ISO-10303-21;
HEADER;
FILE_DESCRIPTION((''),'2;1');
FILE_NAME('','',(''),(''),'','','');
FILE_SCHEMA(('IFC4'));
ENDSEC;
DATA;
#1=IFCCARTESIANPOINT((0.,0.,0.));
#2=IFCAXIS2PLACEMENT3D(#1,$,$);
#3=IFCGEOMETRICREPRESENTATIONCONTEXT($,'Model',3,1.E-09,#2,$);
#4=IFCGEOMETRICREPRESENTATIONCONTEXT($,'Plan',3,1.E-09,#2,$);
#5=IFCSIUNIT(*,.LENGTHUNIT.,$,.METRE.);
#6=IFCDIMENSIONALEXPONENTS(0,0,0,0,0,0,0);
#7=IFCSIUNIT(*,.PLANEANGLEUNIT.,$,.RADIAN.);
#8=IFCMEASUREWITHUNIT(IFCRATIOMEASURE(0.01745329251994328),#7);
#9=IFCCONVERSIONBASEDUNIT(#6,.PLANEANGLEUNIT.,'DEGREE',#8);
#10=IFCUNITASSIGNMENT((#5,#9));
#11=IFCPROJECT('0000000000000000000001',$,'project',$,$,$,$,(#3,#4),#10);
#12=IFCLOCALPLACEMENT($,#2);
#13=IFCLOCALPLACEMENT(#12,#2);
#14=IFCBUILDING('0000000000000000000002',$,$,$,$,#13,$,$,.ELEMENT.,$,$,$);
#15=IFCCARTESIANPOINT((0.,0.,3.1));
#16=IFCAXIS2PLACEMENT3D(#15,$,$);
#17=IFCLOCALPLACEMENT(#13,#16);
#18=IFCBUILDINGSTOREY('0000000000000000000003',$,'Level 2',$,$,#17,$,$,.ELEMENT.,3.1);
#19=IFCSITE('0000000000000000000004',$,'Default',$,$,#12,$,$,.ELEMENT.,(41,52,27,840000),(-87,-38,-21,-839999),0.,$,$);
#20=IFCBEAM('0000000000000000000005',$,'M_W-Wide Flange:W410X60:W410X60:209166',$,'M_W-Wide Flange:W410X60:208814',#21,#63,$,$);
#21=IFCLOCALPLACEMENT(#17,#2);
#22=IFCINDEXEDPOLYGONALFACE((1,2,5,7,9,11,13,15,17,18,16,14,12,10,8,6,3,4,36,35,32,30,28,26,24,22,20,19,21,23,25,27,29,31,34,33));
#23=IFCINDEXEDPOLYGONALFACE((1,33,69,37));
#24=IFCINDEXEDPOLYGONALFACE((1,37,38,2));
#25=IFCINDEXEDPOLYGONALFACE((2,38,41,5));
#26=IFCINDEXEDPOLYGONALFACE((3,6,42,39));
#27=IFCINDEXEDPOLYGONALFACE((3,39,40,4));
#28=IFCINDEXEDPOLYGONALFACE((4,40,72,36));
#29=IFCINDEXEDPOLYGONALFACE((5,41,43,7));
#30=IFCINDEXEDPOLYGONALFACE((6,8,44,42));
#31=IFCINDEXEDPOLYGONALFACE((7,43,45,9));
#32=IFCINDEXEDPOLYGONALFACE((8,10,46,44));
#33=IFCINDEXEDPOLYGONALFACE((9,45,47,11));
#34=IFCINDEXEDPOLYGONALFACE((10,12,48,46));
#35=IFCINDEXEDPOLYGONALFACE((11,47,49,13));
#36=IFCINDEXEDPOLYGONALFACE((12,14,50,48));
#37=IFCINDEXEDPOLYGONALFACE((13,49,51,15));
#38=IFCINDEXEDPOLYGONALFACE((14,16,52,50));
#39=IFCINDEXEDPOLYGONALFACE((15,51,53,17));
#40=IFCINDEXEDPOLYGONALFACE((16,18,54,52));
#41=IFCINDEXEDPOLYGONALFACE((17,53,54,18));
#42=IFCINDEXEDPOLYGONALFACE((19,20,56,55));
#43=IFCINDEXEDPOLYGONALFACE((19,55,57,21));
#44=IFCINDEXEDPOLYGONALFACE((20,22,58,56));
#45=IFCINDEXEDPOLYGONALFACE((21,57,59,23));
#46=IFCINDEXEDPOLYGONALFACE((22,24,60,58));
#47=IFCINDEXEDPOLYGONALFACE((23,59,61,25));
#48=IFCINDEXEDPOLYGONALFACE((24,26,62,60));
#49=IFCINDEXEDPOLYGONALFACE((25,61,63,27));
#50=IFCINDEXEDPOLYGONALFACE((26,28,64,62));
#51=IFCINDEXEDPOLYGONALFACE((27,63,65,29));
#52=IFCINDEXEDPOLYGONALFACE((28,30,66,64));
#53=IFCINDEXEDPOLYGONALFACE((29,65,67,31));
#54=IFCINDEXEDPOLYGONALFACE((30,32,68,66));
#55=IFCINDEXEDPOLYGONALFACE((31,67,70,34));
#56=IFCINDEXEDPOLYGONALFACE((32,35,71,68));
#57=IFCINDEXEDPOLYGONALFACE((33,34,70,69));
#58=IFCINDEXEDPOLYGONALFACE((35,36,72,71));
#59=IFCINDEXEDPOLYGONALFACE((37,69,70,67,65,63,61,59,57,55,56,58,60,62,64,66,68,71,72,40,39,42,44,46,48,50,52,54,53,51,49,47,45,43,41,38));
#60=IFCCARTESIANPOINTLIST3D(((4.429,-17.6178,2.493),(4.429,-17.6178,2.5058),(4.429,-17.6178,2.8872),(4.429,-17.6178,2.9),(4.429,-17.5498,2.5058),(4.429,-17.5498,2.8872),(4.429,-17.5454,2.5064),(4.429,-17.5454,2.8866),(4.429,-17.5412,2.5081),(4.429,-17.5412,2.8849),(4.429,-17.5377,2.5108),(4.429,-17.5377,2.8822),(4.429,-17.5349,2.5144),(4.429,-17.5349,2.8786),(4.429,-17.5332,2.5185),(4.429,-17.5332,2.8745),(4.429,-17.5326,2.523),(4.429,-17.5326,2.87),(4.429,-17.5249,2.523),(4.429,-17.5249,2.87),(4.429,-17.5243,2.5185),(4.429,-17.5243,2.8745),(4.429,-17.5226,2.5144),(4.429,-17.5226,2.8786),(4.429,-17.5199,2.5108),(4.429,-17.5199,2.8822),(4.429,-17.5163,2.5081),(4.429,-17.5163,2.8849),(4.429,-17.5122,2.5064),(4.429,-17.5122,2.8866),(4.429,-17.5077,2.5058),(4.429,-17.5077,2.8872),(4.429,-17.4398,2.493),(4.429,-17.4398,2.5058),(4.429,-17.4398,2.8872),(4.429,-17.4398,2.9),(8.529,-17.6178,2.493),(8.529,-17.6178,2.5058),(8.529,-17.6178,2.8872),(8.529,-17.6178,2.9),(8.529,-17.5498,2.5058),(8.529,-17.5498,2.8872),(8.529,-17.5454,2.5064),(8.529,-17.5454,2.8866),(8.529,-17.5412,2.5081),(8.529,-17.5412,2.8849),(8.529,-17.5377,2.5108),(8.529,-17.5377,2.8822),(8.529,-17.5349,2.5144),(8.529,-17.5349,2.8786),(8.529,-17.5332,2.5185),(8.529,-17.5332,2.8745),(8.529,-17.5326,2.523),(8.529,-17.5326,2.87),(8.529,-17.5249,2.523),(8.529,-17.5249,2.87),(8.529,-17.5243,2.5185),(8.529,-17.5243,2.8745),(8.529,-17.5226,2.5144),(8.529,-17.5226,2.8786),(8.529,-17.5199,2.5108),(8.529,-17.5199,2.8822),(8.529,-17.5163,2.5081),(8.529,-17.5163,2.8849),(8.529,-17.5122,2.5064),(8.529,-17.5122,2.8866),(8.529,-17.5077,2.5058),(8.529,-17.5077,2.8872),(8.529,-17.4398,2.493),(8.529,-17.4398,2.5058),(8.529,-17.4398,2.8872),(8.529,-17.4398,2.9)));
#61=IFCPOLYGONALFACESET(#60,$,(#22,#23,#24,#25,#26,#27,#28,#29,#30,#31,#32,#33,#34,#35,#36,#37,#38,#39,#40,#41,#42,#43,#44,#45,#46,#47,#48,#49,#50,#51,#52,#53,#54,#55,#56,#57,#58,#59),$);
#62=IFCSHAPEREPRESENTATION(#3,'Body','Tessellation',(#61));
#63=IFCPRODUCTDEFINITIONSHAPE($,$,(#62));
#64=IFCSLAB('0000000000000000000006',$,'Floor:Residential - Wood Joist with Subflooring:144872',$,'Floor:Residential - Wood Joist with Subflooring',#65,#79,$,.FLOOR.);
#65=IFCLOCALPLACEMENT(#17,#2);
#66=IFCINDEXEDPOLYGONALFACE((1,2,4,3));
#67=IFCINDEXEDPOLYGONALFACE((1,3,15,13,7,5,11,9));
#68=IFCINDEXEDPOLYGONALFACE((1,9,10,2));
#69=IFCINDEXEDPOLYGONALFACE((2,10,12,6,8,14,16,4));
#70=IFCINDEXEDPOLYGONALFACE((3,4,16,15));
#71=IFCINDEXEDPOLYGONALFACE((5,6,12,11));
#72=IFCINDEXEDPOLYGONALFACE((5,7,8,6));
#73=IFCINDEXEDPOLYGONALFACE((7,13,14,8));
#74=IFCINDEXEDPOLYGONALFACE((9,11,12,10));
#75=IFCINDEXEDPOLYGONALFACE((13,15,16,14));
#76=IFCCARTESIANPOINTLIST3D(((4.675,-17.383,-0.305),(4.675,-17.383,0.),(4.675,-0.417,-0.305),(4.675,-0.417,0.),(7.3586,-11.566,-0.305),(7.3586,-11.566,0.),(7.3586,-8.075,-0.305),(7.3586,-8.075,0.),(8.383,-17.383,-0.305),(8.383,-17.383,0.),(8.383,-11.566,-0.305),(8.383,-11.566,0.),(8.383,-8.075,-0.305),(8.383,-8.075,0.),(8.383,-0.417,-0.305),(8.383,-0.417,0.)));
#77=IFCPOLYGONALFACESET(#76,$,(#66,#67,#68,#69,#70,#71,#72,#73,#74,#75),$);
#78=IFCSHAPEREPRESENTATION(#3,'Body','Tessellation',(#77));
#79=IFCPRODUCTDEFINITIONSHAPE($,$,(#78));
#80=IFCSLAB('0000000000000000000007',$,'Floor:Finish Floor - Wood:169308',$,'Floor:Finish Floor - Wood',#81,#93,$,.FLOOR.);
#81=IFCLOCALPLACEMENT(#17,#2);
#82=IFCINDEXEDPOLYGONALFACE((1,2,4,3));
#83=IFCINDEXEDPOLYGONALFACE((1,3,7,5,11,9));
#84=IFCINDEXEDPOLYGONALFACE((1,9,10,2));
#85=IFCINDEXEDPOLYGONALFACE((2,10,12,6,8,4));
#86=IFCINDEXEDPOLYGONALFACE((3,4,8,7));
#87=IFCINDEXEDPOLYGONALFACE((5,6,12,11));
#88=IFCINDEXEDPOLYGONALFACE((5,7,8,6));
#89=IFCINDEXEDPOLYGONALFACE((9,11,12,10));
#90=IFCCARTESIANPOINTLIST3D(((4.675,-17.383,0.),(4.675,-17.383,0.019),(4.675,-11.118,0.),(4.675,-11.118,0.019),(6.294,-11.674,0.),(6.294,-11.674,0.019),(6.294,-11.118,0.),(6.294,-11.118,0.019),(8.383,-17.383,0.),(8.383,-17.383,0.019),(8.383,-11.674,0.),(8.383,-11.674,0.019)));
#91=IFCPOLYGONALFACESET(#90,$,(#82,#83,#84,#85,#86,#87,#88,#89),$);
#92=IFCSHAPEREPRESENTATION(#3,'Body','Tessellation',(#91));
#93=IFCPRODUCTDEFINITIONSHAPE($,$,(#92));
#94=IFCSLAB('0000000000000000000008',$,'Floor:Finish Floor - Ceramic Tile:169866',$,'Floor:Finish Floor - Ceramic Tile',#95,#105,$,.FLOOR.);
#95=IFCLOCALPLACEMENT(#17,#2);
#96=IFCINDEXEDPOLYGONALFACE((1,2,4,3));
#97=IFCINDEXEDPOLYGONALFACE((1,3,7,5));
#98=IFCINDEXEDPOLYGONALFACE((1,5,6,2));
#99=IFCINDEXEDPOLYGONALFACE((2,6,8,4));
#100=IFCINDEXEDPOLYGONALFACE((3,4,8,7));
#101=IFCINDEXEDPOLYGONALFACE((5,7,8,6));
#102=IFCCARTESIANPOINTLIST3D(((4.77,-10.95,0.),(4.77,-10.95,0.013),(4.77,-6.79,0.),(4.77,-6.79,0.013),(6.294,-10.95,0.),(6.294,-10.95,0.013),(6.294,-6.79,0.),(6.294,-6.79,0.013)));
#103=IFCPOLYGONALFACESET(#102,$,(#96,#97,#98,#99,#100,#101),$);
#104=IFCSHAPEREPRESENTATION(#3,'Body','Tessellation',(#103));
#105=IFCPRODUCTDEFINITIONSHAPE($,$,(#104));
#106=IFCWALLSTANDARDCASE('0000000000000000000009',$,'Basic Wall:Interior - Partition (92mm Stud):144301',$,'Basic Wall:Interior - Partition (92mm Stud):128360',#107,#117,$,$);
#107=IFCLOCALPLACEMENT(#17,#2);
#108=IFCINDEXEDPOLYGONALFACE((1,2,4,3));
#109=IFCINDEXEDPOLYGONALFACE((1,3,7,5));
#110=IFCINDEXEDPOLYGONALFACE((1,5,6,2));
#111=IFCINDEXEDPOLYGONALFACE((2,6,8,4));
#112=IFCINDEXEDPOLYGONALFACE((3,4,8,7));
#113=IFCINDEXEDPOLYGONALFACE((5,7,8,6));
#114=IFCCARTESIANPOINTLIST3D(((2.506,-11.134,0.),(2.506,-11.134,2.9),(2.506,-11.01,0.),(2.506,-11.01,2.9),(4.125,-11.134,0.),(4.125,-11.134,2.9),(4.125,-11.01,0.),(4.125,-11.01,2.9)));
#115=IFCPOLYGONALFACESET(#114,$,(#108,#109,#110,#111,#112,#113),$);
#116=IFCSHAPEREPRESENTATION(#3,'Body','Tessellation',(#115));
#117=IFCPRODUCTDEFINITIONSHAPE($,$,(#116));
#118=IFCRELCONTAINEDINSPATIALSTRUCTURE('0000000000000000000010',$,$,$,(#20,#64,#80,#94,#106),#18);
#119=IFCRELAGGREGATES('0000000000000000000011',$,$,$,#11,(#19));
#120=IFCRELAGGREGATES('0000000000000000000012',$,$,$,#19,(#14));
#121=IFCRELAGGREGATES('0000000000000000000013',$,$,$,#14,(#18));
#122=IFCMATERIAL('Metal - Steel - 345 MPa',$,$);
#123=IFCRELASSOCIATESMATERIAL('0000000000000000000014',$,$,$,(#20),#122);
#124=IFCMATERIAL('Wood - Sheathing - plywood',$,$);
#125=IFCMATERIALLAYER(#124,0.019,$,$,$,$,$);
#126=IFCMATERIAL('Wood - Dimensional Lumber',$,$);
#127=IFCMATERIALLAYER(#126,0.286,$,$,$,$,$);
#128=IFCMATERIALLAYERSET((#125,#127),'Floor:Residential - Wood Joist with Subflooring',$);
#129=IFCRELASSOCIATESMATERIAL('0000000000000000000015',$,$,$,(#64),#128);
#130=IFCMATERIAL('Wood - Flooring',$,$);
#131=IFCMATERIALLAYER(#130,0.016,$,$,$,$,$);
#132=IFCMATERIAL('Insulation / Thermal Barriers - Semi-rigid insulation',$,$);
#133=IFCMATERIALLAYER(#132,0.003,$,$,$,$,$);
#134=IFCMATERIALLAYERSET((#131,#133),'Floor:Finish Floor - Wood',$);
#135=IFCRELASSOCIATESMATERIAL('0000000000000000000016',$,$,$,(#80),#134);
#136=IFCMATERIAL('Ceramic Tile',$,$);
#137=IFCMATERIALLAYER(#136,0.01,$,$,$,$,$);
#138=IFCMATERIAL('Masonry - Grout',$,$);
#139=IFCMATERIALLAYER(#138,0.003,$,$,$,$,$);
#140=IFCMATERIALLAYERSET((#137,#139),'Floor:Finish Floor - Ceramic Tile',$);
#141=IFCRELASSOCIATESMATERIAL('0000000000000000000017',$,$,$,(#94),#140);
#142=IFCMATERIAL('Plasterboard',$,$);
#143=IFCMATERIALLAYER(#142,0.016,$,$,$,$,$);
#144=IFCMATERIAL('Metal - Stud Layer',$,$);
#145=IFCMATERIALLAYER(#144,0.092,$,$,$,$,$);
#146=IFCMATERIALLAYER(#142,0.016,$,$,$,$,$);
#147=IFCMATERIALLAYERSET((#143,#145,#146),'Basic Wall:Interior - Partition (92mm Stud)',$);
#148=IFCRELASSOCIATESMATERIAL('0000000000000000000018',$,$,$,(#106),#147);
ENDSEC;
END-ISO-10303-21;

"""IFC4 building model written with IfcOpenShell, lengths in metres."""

from ifc_helpers import new_model, entity, si_unit, converted_unit, frame, frame_2d, origin, place, context, project, spatial, polyline, circle_curve, parameter, trimmed, segment, composite_curve, rectangle, outline, extrude, material, layer, layer_set, layer_usage, element, save


model = new_model("IFC4")

# Units and contexts
model_context = context("Model", 3, precision=1e-09, world=origin())
plan_context = context("Plan", 3, precision=1e-09, world=origin())
ifc_project = project(units=[si_unit("LENGTHUNIT", "METRE"), converted_unit("PLANEANGLEUNIT", "DEGREE", entity("IfcRatioMeasure", 0.01745329251994328), si_unit("PLANEANGLEUNIT", "RADIAN"), dimensions=[0, 0, 0, 0, 0, 0, 0])], contexts=[model_context, plan_context])

# Site, building, storey
site_placement = place(None, origin())
site = spatial("IfcSite", under=ifc_project, at=site_placement, Name="Default", CompositionType="ELEMENT", RefLatitude=(41, 52, 27, 840000), RefLongitude=(-87, -38, -21, -839999), RefElevation=0.0)
building_placement = place(site_placement, origin())
building = spatial("IfcBuilding", under=site, at=building_placement, CompositionType="ELEMENT")
storey_placement = place(building_placement, frame((0.0, 0.0, 3.1)))
storey = spatial("IfcBuildingStorey", under=building, at=storey_placement, Name="Level 2", CompositionType="ELEMENT", Elevation=3.1)

# Beam
ifc_material_1 = material(Name="Metal - Steel - 345 MPa")
beam_placement = place(storey_placement, frame((4.429, -17.5288, 2.9), z_axis=(0.0, 0.0, 1.0), x_axis=(0.0, -1.0, 0.0)))
element("IfcBeam", 1, at=beam_placement, inside=storey, material=ifc_material_1, Name="M_W-Wide Flange:W410X60:W410X60:209166", ObjectType="M_W-Wide Flange:W410X60:208814", context=model_context, shape_type="SweptSolid", body=[
    extrude(outline(composite_curve([segment(polyline([(-0.089, -0.1907), (-0.089, -0.2035)]), True, "CONTINUOUS"), segment(polyline([(-0.089, -0.2035), (0.089, -0.2035)]), True, "CONTINUOUS"), segment(polyline([(0.089, -0.2035), (0.089, -0.1907)]), True, "CONTINUOUS"), segment(polyline([(0.089, -0.1907), (0.021, -0.1907)]), True, "CONTINUOUS"), segment(trimmed(circle_curve(frame_2d((0.021, -0.1735), x_axis=(0.0, -1.0)), 0.0172), [parameter(270.0)], [parameter(360.0)], True, "PARAMETER"), False, "CONTINUOUS"), segment(polyline([(0.0038, -0.1735), (0.0038, 0.1735)]), True, "CONTINUOUS"), segment(trimmed(circle_curve(frame_2d((0.021, 0.1735), x_axis=(-1.0, 0.0)), 0.0172), [parameter(270.0)], [parameter(360.0)], True, "PARAMETER"), False, "CONTINUOUS"), segment(polyline([(0.021, 0.1907), (0.089, 0.1907)]), True, "CONTINUOUS"), segment(polyline([(0.089, 0.1907), (0.089, 0.2035)]), True, "CONTINUOUS"), segment(polyline([(0.089, 0.2035), (-0.089, 0.2035)]), True, "CONTINUOUS"), segment(polyline([(-0.089, 0.2035), (-0.089, 0.1907)]), True, "CONTINUOUS"), segment(polyline([(-0.089, 0.1907), (-0.0211, 0.1907)]), True, "CONTINUOUS"), segment(trimmed(circle_curve(frame_2d((-0.0211, 0.1735), x_axis=(0.0, 1.0)), 0.0172), [parameter(270.0)], [parameter(0.0)], True, "PARAMETER"), False, "CONTINUOUS"), segment(polyline([(-0.0039, 0.1735), (-0.0039, -0.1735)]), True, "CONTINUOUS"), segment(trimmed(circle_curve(frame_2d((-0.0211, -0.1735), x_axis=(1.0, 0.0)), 0.0172), [parameter(270.0)], [parameter(0.0)], True, "PARAMETER"), False, "CONTINUOUS"), segment(polyline([(-0.0211, -0.1907), (-0.089, -0.1907)]), True, "CONTINUOUS")], self_intersect=False)), frame((0.0, 0.0, -0.2035), z_axis=(0.0, -1.0, 0.0), x_axis=(1.0, 0.0, 0.0)), (0.0, 0.0, -1.0), 4.1),
])

# Slabs
ifc_material_2 = material(Name="Wood - Sheathing - plywood")
ifc_layer_1 = layer(ifc_material_2, 0.019)
ifc_material_3 = material(Name="Wood - Dimensional Lumber")
ifc_layer_2 = layer(ifc_material_3, 0.286)
ifc_layer_set_1 = layer_set([ifc_layer_1, ifc_layer_2], Name="Floor:Residential - Wood Joist with Subflooring")
ifc_layer_usage_1 = layer_usage(ifc_layer_set_1, "AXIS3", "POSITIVE", 0.0)
slab_1_placement = place(storey_placement, frame((4.675, -17.383, -0.305)))
element("IfcSlab", 2, at=slab_1_placement, inside=storey, material=ifc_layer_usage_1, Name="Floor:Residential - Wood Joist with Subflooring:144872", ObjectType="Floor:Residential - Wood Joist with Subflooring", PredefinedType="FLOOR", context=model_context, shape_type="SweptSolid", body=[
    extrude(outline(polyline([(-1.854, 8.483), (-1.854, 0.825), (-0.8296, 0.825), (-0.8296, -2.666), (-1.854, -2.666), (-1.854, -8.483), (1.854, -8.483), (1.854, 8.483), (-1.854, 8.483)])), frame((1.854, 8.483, 0.305), z_axis=(0.0, 0.0, -1.0), x_axis=(-1.0, 0.0, 0.0)), (0.0, 0.0, 1.0), 0.305),
])
ifc_material_4 = material(Name="Wood - Flooring")
ifc_layer_3 = layer(ifc_material_4, 0.016)
ifc_material_5 = material(Name="Insulation / Thermal Barriers - Semi-rigid insulation")
ifc_layer_4 = layer(ifc_material_5, 0.003)
ifc_layer_set_2 = layer_set([ifc_layer_3, ifc_layer_4], Name="Floor:Finish Floor - Wood")
ifc_layer_usage_2 = layer_usage(ifc_layer_set_2, "AXIS3", "POSITIVE", 0.0)
slab_2_placement = place(storey_placement, frame((4.675, -17.383, 0.0)))
element("IfcSlab", 3, at=slab_2_placement, inside=storey, material=ifc_layer_usage_2, Name="Floor:Finish Floor - Wood:169308", ObjectType="Floor:Finish Floor - Wood", PredefinedType="FLOOR", context=model_context, shape_type="SweptSolid", body=[
    extrude(outline(polyline([(-1.854, 2.5765), (-1.854, -3.1325), (1.854, -3.1325), (1.854, 3.1325), (0.235, 3.1325), (0.235, 2.5765), (-1.854, 2.5765)])), frame((1.854, 3.1325, 0.019), z_axis=(0.0, 0.0, -1.0), x_axis=(-1.0, 0.0, 0.0)), (0.0, 0.0, 1.0), 0.019),
])
ifc_material_6 = material(Name="Ceramic Tile")
ifc_layer_5 = layer(ifc_material_6, 0.01)
ifc_material_7 = material(Name="Masonry - Grout")
ifc_layer_6 = layer(ifc_material_7, 0.003)
ifc_layer_set_3 = layer_set([ifc_layer_5, ifc_layer_6], Name="Floor:Finish Floor - Ceramic Tile")
ifc_layer_usage_3 = layer_usage(ifc_layer_set_3, "AXIS3", "POSITIVE", 0.0)
slab_3_placement = place(storey_placement, frame((4.77, -10.95, 0.0)))
element("IfcSlab", 4, at=slab_3_placement, inside=storey, material=ifc_layer_usage_3, Name="Floor:Finish Floor - Ceramic Tile:169866", ObjectType="Floor:Finish Floor - Ceramic Tile", PredefinedType="FLOOR", context=model_context, shape_type="SweptSolid", body=[
    extrude(rectangle(XDim=4.16, YDim=1.524, at=frame_2d((0.0, 0.0), x_axis=(0.0, -1.0))), frame((0.762, 2.08, 0.013), z_axis=(0.0, 0.0, -1.0), x_axis=(-1.0, 0.0, 0.0)), (0.0, 0.0, 1.0), 0.013),
])

# Shared definitions
ifc_material_8 = material(Name="Metal - Stud Layer")
ifc_material_9 = material(Name="Plasterboard")

# Wall
ifc_layer_7 = layer(ifc_material_9, 0.016)
ifc_layer_8 = layer(ifc_material_8, 0.092)
ifc_layer_9 = layer(ifc_material_9, 0.016)
ifc_layer_set_4 = layer_set([ifc_layer_7, ifc_layer_8, ifc_layer_9], Name="Basic Wall:Interior - Partition (92mm Stud)")
ifc_layer_usage_4 = layer_usage(ifc_layer_set_4, "AXIS2", "NEGATIVE", 0.062)
wall_1_placement = place(storey_placement, frame((4.125, -11.072, 0.0), z_axis=(0.0, 0.0, 1.0), x_axis=(-1.0, 0.0, 0.0)))
element("IfcWallStandardCase", 5, at=wall_1_placement, inside=storey, material=ifc_layer_usage_4, Name="Basic Wall:Interior - Partition (92mm Stud):144301", ObjectType="Basic Wall:Interior - Partition (92mm Stud):128360", context=model_context, shape_type="SweptSolid", body=[
    extrude(rectangle(XDim=1.619, YDim=0.124, at=frame_2d((0.8095, 0.0), x_axis=(-1.0, 0.0))), origin(), (0.0, 0.0, 1.0), 2.9),
])

save(model, "model.ifc")
